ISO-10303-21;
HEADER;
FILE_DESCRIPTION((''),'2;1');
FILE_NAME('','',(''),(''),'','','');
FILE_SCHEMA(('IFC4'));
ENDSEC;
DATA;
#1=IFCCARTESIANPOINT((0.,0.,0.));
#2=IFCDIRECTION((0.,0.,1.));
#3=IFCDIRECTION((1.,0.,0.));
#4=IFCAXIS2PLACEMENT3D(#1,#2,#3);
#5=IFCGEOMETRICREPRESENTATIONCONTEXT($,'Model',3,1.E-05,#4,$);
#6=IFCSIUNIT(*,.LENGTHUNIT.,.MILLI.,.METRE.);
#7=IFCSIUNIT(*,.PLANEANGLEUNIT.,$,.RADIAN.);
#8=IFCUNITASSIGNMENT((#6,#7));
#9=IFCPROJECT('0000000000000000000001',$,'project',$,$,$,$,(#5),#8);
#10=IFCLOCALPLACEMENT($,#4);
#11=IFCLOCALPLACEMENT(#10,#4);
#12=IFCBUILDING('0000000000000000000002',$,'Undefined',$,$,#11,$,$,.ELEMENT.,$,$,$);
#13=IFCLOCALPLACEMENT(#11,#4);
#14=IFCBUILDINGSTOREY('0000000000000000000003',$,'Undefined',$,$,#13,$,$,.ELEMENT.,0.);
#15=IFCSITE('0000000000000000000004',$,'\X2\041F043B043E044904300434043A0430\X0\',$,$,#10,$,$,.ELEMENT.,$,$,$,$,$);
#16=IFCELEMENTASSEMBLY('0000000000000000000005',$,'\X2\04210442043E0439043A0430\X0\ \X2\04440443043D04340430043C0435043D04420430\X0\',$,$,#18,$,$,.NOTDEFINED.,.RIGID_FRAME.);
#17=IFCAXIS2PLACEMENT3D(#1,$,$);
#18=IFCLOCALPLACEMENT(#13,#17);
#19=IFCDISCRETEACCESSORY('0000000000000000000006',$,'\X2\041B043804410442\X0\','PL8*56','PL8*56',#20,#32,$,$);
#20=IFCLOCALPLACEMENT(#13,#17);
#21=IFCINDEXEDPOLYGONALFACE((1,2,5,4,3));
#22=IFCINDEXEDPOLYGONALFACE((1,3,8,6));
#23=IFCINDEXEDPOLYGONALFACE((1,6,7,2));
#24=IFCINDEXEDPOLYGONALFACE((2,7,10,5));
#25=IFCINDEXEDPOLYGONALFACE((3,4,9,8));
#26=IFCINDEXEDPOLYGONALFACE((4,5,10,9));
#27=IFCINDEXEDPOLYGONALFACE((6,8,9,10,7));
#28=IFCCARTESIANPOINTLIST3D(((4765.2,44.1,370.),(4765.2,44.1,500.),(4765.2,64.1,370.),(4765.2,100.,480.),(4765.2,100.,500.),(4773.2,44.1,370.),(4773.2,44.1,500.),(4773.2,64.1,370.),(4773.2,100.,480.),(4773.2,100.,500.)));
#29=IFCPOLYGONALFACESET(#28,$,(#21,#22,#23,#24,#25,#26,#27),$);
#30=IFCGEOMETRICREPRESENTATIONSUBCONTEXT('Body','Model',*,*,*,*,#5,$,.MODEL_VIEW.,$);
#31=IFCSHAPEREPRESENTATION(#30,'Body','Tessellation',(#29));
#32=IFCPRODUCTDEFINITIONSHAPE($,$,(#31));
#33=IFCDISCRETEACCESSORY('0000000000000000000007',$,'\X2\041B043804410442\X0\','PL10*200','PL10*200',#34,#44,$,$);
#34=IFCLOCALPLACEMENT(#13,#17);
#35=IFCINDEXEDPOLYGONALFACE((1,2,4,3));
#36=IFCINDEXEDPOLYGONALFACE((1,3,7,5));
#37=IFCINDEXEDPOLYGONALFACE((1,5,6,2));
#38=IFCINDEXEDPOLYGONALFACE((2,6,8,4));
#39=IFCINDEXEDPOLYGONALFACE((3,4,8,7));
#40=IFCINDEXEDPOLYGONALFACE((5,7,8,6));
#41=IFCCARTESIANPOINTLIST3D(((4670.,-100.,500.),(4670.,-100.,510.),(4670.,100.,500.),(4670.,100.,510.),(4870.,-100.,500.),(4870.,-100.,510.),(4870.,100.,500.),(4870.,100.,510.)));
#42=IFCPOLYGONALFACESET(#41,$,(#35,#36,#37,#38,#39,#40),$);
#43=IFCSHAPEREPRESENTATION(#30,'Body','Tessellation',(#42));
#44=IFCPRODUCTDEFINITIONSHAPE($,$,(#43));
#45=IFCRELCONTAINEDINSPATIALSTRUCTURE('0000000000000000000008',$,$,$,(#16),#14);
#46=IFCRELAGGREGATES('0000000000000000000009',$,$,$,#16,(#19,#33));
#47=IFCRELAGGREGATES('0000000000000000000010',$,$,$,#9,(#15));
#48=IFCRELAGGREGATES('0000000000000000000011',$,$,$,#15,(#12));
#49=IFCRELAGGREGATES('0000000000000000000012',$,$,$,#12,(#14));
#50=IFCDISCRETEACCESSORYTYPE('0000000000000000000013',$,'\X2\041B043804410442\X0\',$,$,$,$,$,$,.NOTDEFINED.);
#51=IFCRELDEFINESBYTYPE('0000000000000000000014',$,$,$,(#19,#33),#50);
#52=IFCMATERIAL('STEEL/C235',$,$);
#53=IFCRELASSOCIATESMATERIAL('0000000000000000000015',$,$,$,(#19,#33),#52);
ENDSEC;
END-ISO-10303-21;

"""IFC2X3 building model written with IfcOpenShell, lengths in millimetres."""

from ifc_helpers import new_model, si_unit, frame, origin_with_axes, place, context, subcontext, project, spatial, polyline, outline, extrude, material, type_object, element, aggregate, save


model = new_model("IFC2X3")

# Units and contexts
model_context = context("Model", 3, precision=1e-05, world=origin_with_axes())
body_context = subcontext(model_context, "Body", "Model", "MODEL_VIEW")
ifc_project = project(units=[si_unit("LENGTHUNIT", "METRE", prefix="MILLI"), si_unit("PLANEANGLEUNIT", "RADIAN")], contexts=[model_context])

# Site, building, storey
site_placement = place(None, origin_with_axes())
site = spatial("IfcSite", under=ifc_project, at=site_placement, Name="Площадка", CompositionType="ELEMENT")
building_placement = place(site_placement, origin_with_axes())
building = spatial("IfcBuilding", under=site, at=building_placement, Name="Undefined", CompositionType="ELEMENT")
storey_placement = place(building_placement, origin_with_axes())
storey = spatial("IfcBuildingStorey", under=building, at=storey_placement, Name="Undefined", CompositionType="ELEMENT", Elevation=0.0)

# Element assembly
ifc_material_1 = material(Name="STEEL/C235")
assembly_1_placement = place(storey_placement, origin_with_axes())
assembly_1 = element("IfcElementAssembly", 1, at=assembly_1_placement, inside=storey, Name="Стойка фундамента", AssemblyPlace="NOTDEFINED", PredefinedType="RIGID_FRAME")

# Discrete accessories
discrete_accessory_type = type_object("IfcDiscreteAccessoryType", Name="Лист")
discrete_accessory_1_placement = place(assembly_1_placement, frame((4769.2, 44.1, 500.0), z_axis=(-1.0, 0.0, 0.0), x_axis=(0.0, 1.0, 0.0)))
discrete_accessory_1 = element("IfcDiscreteAccessory", 2, at=discrete_accessory_1_placement, type_object=discrete_accessory_type, material=ifc_material_1, Name="Лист", Description="PL8*56", ObjectType="PL8*56", context=body_context, shape_type="SweptSolid", body=[
    extrude(outline(polyline([(0.0, 0.0), (55.9, 0.0), (55.9, 20.0), (20.0, 130.0), (0.0, 130.0), (0.0, 0.0)])), frame((0.0, 0.0, -4.0), z_axis=(0.0, 0.0, 1.0), x_axis=(1.0, 0.0, 0.0)), (0.0, 0.0, 1.0), 8.0),
])
discrete_accessory_2_placement = place(assembly_1_placement, frame((4670.0, -100.0, 505.0), z_axis=(0.0, 0.0, 1.0), x_axis=(1.0, 0.0, 0.0)))
discrete_accessory_2 = element("IfcDiscreteAccessory", 3, at=discrete_accessory_2_placement, type_object=discrete_accessory_type, material=ifc_material_1, Name="Лист", Description="PL10*200", ObjectType="PL10*200", context=body_context, shape_type="SweptSolid", body=[
    extrude(outline(polyline([(0.0, 0.0), (200.0, 0.0), (200.0, 200.0), (0.0, 200.0), (0.0, 0.0)])), frame((0.0, 0.0, -5.0), z_axis=(0.0, 0.0, 1.0), x_axis=(1.0, 0.0, 0.0)), (0.0, 0.0, 1.0), 10.0),
])
aggregate(assembly_1, [discrete_accessory_1, discrete_accessory_2])

save(model, "model.ifc")
